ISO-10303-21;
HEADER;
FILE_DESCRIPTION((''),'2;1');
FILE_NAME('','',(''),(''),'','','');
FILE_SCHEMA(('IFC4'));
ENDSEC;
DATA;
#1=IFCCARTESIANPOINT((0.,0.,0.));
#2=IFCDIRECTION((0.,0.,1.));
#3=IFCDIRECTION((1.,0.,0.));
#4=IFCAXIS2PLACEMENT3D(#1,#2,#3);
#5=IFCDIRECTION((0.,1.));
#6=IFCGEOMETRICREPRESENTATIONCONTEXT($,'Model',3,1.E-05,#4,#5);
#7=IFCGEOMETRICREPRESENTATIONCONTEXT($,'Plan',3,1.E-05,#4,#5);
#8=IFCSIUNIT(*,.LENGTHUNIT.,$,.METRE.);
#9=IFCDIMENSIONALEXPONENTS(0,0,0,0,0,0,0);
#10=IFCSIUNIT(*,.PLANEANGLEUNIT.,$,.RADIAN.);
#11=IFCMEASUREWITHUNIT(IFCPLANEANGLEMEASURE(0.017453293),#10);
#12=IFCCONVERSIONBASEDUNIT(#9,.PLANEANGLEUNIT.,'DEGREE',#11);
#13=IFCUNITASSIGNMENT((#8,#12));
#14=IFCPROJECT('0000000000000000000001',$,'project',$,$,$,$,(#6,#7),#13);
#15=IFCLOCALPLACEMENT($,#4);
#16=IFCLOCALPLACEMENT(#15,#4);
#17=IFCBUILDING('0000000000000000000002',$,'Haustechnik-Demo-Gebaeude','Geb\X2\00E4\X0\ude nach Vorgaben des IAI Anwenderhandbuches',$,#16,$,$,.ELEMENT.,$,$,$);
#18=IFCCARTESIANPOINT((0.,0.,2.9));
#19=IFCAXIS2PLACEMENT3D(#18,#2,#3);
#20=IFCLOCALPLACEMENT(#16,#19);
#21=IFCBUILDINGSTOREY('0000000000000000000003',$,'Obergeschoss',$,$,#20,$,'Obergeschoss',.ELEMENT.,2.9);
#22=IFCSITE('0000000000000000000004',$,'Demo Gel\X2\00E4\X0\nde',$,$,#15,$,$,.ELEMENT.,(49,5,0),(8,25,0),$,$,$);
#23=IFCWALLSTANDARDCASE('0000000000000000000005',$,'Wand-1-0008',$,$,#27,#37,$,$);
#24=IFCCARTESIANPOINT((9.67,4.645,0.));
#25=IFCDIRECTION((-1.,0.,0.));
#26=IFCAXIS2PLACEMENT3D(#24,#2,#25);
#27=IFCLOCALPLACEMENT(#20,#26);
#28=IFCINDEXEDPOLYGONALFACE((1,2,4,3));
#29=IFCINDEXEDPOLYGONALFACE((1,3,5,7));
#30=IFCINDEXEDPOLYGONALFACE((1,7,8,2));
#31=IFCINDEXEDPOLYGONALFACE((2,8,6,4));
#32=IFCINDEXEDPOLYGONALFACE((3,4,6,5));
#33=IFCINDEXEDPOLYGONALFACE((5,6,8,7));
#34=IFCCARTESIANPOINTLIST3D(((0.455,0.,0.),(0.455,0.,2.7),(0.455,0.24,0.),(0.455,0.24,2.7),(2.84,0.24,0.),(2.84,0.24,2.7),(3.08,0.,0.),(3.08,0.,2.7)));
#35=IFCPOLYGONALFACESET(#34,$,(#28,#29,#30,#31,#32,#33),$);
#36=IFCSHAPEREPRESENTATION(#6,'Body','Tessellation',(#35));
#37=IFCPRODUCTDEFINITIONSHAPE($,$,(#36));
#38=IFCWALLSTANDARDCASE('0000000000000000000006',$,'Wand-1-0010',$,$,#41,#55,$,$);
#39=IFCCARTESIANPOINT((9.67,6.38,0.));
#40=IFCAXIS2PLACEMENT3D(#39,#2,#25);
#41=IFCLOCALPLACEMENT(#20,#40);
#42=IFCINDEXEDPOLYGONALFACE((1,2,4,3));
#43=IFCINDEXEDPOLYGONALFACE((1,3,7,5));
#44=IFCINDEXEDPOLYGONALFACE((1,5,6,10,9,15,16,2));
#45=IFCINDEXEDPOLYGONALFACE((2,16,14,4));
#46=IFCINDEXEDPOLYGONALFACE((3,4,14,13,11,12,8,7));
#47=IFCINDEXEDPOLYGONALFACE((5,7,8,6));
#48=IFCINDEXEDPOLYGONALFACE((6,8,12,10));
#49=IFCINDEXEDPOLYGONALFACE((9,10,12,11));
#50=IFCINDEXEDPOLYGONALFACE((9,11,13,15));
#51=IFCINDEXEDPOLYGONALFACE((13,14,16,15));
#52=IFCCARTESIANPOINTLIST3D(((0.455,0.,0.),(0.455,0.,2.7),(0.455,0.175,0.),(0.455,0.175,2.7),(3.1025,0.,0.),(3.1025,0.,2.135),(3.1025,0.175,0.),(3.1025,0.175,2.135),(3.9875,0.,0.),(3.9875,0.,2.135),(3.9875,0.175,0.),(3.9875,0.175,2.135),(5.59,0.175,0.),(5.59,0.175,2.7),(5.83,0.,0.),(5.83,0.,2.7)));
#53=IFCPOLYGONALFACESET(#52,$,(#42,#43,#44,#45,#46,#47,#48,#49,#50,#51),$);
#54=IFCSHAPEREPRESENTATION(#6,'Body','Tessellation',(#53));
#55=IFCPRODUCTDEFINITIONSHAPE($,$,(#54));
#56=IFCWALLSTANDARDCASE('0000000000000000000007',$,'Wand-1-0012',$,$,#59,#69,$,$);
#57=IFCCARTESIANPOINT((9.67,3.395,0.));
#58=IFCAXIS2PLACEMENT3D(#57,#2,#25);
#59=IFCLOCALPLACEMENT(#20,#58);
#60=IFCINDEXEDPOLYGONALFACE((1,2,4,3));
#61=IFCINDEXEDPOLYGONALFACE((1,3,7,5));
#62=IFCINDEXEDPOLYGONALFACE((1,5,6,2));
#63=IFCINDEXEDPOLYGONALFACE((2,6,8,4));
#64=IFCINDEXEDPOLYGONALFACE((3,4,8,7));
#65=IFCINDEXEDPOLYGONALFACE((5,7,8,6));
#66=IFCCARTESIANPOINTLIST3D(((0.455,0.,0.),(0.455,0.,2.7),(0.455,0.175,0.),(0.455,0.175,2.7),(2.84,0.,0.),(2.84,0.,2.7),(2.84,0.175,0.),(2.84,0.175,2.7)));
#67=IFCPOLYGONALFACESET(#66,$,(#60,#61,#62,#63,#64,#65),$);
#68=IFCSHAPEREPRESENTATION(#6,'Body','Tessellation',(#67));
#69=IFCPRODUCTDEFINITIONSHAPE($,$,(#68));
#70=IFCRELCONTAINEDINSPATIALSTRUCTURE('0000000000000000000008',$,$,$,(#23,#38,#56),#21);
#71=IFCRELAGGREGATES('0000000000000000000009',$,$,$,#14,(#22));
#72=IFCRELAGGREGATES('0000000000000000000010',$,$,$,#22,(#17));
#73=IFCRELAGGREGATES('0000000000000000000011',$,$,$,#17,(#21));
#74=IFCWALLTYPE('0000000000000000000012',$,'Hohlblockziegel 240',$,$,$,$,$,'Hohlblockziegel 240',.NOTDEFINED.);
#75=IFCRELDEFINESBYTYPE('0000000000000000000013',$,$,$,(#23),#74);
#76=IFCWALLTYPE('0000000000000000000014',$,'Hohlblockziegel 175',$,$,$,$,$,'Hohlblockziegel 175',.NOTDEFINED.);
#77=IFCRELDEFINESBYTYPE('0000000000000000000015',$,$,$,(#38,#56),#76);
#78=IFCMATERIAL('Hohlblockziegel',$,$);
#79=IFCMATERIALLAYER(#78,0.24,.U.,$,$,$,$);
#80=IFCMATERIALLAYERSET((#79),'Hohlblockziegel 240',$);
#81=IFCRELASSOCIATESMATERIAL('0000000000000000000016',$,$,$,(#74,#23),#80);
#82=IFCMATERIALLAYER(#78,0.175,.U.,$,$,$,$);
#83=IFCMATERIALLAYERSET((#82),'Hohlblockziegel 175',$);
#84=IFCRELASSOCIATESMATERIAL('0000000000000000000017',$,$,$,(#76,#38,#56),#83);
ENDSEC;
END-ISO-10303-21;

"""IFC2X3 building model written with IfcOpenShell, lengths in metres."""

from ifc_helpers import new_model, entity, si_unit, converted_unit, direction, frame, frame_2d, origin_with_axes, place, context, project, spatial, polyline, rectangle, outline, extrude, material, layer, layer_set, layer_usage, type_object, element, save


model = new_model("IFC2X3")

# Units and contexts
model_context = context("Model", 3, precision=1e-05, world=origin_with_axes(), true_north=direction((0.0, 1.0)))
plan_context = context("Plan", 3, precision=1e-05, world=origin_with_axes(), true_north=direction((0.0, 1.0)))
ifc_project = project(units=[si_unit("LENGTHUNIT", "METRE"), converted_unit("PLANEANGLEUNIT", "DEGREE", entity("IfcPlaneAngleMeasure", 0.017453293), si_unit("PLANEANGLEUNIT", "RADIAN"), dimensions=[0, 0, 0, 0, 0, 0, 0])], contexts=[model_context, plan_context])

# Site, building, storey
site_placement = place(None, origin_with_axes())
site = spatial("IfcSite", under=ifc_project, at=site_placement, Name="Demo Gelände", CompositionType="ELEMENT", RefLatitude=(49, 5, 0), RefLongitude=(8, 25, 0))
building_placement = place(site_placement, origin_with_axes())
building = spatial("IfcBuilding", under=site, at=building_placement, Name="Haustechnik-Demo-Gebaeude", Description="Gebäude nach Vorgaben des IAI Anwenderhandbuches", CompositionType="ELEMENT")
storey_placement = place(building_placement, frame((0.0, 0.0, 2.9), z_axis=(0.0, 0.0, 1.0), x_axis=(1.0, 0.0, 0.0)))
storey = spatial("IfcBuildingStorey", under=building, at=storey_placement, Name="Obergeschoss", LongName="Obergeschoss", CompositionType="ELEMENT", Elevation=2.9)

# Wall
ifc_material_1 = material(Name="Hohlblockziegel")
ifc_layer_1 = layer(ifc_material_1, 0.24, ventilated="UNKNOWN")
ifc_layer_set_1 = layer_set([ifc_layer_1], Name="Hohlblockziegel 240")
wall_type_1 = type_object("IfcWallType", Name="Hohlblockziegel 240", ElementType="Hohlblockziegel 240", PredefinedType="NOTDEFINED", material=ifc_layer_set_1)
ifc_layer_usage_1 = layer_usage(ifc_layer_set_1, "AXIS2", "POSITIVE", 0.0)
wall_1_placement = place(storey_placement, frame((9.67, 4.645, 0.0), z_axis=(0.0, 0.0, 1.0), x_axis=(-1.0, 0.0, 0.0)))
element("IfcWallStandardCase", 1, at=wall_1_placement, inside=storey, type_object=wall_type_1, material=ifc_layer_usage_1, Name="Wand-1-0008", context=model_context, shape_type="SweptSolid", body=[
    extrude(outline(polyline([(0.455, 0.0), (3.08, 0.0), (2.84, 0.24), (0.455, 0.24), (0.455, 0.0)])), origin_with_axes(), (0.0, 0.0, 1.0), 2.7),
])

# Wall, opening
ifc_layer_2 = layer(ifc_material_1, 0.175, ventilated="UNKNOWN")
ifc_layer_set_2 = layer_set([ifc_layer_2], Name="Hohlblockziegel 175")
ifc_layer_usage_2 = layer_usage(ifc_layer_set_2, "AXIS2", "POSITIVE", 0.0)
wall_type_2 = type_object("IfcWallType", Name="Hohlblockziegel 175", ElementType="Hohlblockziegel 175", PredefinedType="NOTDEFINED", material=ifc_layer_set_2)
wall_2_placement = place(storey_placement, frame((9.67, 6.38, 0.0), z_axis=(0.0, 0.0, 1.0), x_axis=(-1.0, 0.0, 0.0)))
wall_2 = element("IfcWallStandardCase", 2, at=wall_2_placement, inside=storey, type_object=wall_type_2, material=ifc_layer_usage_2, Name="Wand-1-0010", context=model_context, shape_type="SweptSolid", body=[
    extrude(outline(polyline([(0.455, 0.0), (5.83, 0.0), (5.59, 0.175), (0.455, 0.175), (0.455, 0.0)])), origin_with_axes(), (0.0, 0.0, 1.0), 2.7),
])
opening_1_placement = place(wall_2_placement, frame((3.545, 0.0, 0.0), z_axis=(0.0, 0.0, 1.0), x_axis=(1.0, 0.0, 0.0)))
element("IfcOpeningElement", 3, at=opening_1_placement, cuts=wall_2, ObjectType="Opening", context=model_context, shape_type="SweptSolid", body=[
    extrude(rectangle(XDim=0.885, YDim=2.135, at=frame_2d((0.0, 1.0675), x_axis=(-1.0, 0.0))), frame((0.0, 0.0, 0.0), z_axis=(0.0, 1.0, 0.0), x_axis=(-1.0, 0.0, 0.0)), (0.0, 0.0, 1.0), 0.175),
])

# Wall
ifc_layer_usage_3 = layer_usage(ifc_layer_set_2, "AXIS2", "POSITIVE", 0.0)
wall_3_placement = place(storey_placement, frame((9.67, 3.395, 0.0), z_axis=(0.0, 0.0, 1.0), x_axis=(-1.0, 0.0, 0.0)))
element("IfcWallStandardCase", 4, at=wall_3_placement, inside=storey, type_object=wall_type_2, material=ifc_layer_usage_3, Name="Wand-1-0012", context=model_context, shape_type="SweptSolid", body=[
    extrude(outline(polyline([(0.455, 0.0), (2.84, 0.0), (2.84, 0.175), (0.455, 0.175), (0.455, 0.0)])), origin_with_axes(), (0.0, 0.0, 1.0), 2.7),
])

save(model, "model.ifc")
